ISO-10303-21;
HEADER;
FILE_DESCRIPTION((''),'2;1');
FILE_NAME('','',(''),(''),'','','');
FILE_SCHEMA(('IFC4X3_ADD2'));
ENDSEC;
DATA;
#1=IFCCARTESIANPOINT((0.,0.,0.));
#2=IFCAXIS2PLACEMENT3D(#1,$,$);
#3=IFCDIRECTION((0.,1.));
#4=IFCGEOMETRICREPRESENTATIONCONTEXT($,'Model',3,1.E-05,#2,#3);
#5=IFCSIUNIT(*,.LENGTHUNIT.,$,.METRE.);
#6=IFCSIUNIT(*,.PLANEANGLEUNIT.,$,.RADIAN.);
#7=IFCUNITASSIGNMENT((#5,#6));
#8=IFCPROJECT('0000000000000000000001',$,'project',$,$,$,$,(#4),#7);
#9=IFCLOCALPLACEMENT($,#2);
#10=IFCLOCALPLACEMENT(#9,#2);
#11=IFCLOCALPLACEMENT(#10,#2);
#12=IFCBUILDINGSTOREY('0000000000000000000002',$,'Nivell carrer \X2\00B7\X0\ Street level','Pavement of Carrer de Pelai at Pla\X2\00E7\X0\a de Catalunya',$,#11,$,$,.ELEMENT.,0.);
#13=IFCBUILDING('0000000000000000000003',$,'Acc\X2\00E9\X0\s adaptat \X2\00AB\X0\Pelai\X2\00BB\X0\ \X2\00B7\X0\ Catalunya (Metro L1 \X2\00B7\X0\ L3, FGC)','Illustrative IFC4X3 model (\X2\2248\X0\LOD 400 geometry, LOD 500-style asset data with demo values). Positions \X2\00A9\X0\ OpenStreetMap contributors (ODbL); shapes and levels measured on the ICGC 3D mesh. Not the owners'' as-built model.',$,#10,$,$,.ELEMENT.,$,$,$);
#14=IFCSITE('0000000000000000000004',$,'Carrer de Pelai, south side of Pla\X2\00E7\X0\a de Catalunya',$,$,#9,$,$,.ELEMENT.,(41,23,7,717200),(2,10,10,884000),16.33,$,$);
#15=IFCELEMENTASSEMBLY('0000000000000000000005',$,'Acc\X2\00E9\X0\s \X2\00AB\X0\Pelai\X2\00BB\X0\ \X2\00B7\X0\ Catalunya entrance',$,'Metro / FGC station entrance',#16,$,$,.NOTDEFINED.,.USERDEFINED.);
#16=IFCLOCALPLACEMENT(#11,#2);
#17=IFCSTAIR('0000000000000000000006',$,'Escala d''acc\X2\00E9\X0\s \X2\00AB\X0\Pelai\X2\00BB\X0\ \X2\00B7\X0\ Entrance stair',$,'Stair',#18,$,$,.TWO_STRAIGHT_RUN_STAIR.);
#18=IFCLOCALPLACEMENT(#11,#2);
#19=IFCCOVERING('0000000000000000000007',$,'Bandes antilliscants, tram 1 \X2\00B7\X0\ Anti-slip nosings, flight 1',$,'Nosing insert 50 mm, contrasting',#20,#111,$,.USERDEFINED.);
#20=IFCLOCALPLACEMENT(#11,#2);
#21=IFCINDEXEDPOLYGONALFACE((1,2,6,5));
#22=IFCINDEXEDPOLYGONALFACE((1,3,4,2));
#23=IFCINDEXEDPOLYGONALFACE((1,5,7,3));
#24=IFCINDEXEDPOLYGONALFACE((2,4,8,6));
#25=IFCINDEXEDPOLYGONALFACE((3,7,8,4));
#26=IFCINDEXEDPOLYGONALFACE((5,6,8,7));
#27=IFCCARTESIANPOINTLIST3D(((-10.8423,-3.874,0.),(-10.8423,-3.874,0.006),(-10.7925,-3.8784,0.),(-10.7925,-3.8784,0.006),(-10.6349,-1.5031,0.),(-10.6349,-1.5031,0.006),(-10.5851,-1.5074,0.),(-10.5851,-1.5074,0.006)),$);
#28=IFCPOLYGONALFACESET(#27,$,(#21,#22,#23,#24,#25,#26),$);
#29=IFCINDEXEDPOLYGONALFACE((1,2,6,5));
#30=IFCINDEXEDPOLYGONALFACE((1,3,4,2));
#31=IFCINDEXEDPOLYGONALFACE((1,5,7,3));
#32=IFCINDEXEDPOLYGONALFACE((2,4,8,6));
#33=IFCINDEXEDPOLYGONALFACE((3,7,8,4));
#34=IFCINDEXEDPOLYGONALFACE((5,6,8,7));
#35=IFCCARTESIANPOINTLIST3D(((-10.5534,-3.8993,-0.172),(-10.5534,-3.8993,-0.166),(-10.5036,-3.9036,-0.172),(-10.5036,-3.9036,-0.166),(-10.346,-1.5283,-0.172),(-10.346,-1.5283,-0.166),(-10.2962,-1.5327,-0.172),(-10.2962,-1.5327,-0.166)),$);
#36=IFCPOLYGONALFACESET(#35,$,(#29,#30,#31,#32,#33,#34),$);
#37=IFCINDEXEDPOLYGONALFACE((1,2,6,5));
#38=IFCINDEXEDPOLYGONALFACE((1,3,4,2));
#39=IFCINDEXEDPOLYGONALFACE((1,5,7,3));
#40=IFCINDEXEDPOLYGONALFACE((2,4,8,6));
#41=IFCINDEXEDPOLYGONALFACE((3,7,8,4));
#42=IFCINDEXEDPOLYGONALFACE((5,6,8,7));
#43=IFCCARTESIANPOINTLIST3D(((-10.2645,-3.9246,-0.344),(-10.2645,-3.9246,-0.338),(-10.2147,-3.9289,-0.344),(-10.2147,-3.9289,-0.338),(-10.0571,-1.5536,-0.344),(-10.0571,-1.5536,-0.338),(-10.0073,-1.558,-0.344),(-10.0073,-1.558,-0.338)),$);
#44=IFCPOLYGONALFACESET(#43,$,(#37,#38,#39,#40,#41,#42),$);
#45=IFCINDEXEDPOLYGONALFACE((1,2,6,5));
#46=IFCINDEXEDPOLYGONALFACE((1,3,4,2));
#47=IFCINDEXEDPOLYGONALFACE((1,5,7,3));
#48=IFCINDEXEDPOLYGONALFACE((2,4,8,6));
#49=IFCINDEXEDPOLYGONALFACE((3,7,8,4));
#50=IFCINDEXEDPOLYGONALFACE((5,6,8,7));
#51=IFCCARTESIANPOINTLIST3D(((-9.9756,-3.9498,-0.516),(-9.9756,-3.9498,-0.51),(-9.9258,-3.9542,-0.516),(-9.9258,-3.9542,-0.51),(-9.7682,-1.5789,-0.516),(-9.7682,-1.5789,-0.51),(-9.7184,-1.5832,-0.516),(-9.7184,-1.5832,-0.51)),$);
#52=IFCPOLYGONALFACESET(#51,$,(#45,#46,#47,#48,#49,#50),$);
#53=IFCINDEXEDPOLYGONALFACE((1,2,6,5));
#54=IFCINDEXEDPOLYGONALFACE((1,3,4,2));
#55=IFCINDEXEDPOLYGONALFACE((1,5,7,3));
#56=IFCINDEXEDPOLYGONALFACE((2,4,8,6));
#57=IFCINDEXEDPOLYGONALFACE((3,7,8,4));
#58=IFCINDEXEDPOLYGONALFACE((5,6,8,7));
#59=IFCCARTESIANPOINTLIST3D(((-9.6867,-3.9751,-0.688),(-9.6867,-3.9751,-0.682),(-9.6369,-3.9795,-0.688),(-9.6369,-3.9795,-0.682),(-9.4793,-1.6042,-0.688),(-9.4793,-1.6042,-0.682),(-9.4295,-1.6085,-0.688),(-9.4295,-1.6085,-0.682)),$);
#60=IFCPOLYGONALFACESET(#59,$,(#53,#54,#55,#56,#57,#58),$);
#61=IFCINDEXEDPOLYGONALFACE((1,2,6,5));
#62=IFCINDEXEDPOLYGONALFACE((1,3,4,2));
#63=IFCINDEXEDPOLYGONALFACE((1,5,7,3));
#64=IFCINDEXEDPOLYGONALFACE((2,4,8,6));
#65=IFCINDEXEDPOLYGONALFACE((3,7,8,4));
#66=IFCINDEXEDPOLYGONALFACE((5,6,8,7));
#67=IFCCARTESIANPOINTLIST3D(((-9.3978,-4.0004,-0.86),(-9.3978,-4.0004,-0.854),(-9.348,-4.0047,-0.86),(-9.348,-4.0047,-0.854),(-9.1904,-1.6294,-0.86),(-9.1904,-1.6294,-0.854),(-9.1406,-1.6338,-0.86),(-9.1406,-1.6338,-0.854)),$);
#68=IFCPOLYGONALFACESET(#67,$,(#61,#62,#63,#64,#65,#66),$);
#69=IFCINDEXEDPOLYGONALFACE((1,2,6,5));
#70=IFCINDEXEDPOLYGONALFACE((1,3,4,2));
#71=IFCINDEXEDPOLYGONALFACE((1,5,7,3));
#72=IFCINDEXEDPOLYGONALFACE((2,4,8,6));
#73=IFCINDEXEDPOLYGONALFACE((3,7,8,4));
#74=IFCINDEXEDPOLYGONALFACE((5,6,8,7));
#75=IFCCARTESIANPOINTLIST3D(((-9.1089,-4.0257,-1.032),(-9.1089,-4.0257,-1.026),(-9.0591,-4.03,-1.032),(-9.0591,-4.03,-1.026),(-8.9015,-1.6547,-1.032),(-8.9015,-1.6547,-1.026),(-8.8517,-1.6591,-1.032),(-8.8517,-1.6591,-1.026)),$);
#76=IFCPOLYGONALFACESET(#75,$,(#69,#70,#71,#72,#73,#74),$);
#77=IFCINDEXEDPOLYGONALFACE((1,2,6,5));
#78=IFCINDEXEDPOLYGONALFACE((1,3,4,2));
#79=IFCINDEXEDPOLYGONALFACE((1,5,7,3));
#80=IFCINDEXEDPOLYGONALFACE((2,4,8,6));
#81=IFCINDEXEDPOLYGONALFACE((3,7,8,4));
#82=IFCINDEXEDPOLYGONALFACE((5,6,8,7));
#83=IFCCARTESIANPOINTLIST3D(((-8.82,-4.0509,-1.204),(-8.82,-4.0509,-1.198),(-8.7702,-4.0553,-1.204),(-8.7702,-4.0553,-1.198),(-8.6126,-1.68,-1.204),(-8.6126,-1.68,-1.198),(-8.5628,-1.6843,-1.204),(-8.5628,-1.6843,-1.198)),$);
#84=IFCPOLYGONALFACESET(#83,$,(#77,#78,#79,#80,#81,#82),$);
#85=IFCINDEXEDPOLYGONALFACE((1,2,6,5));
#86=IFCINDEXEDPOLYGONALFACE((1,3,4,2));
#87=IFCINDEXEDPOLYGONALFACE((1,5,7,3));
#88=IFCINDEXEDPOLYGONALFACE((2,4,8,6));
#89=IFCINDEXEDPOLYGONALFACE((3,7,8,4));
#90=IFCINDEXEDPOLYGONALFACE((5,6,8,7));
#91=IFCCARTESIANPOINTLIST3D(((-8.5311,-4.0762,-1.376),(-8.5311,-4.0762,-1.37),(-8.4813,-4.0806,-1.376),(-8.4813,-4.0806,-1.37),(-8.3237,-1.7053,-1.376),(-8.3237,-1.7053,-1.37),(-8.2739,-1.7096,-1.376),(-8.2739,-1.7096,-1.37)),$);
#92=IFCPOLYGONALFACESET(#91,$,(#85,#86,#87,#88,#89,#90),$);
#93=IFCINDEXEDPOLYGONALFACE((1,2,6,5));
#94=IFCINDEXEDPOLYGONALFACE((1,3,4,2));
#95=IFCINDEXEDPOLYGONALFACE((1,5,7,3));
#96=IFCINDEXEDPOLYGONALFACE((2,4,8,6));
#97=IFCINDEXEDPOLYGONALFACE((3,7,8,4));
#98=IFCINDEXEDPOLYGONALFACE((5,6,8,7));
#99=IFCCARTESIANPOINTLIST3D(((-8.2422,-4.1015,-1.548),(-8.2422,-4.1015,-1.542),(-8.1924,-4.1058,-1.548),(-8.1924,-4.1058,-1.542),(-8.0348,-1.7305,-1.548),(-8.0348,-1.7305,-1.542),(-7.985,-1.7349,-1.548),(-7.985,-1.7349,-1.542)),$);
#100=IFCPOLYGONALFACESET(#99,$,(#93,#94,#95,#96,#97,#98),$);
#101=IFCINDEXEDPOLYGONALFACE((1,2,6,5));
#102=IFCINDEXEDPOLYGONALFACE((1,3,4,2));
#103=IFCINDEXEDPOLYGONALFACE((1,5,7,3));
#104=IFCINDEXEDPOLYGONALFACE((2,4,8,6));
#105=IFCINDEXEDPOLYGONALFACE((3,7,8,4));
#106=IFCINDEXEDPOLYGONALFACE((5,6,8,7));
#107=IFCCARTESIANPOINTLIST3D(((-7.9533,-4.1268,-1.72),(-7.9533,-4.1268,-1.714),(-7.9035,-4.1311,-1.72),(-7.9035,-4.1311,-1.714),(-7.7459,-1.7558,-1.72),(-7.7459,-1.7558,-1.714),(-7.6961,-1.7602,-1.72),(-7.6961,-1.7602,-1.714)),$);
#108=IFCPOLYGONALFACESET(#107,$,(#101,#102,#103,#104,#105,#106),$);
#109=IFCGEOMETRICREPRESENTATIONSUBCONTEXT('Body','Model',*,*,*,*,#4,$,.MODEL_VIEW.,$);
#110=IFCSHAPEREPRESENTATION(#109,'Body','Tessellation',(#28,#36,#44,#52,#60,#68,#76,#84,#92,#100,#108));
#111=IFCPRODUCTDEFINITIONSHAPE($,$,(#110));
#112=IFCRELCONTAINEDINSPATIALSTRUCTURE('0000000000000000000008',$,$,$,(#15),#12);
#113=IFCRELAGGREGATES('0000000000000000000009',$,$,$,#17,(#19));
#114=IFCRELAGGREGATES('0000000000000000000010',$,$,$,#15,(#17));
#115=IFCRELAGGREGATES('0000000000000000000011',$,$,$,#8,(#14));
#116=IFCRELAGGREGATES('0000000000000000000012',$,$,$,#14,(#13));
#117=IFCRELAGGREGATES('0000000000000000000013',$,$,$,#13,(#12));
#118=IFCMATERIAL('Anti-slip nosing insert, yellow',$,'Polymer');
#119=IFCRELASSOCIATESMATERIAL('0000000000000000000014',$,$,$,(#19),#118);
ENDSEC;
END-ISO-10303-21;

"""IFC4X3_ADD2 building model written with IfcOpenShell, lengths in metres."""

from ifc_helpers import new_model, si_unit, direction, frame, frame_2d, origin, place, context, subcontext, project, spatial, rectangle, extrude, material, element, aggregate, save


model = new_model("IFC4X3_ADD2")

# Units and contexts
model_context = context("Model", 3, precision=1e-05, world=origin(), true_north=direction((0.0, 1.0)))
body_context = subcontext(model_context, "Body", "Model", "MODEL_VIEW")
ifc_project = project(units=[si_unit("LENGTHUNIT", "METRE"), si_unit("PLANEANGLEUNIT", "RADIAN")], contexts=[model_context])

# Site, building, storey
site_placement = place(None, origin())
site = spatial("IfcSite", under=ifc_project, at=site_placement, Name="Carrer de Pelai, south side of Plaça de Catalunya", CompositionType="ELEMENT", RefLatitude=(41, 23, 7, 717200), RefLongitude=(2, 10, 10, 884000), RefElevation=16.33)
building_placement = place(site_placement, origin())
building = spatial("IfcBuilding", under=site, at=building_placement, Name="Accés adaptat «Pelai» · Catalunya (Metro L1 · L3, FGC)", Description="Illustrative IFC4X3 model (≈LOD 400 geometry, LOD 500-style asset data with demo values). Positions © OpenStreetMap contributors (ODbL); shapes and levels measured on the ICGC 3D mesh. Not the owners' as-built model.", CompositionType="ELEMENT")
storey_placement = place(building_placement, origin())
storey = spatial("IfcBuildingStorey", under=building, at=storey_placement, Name="Nivell carrer · Street level", Description="Pavement of Carrer de Pelai at Plaça de Catalunya", CompositionType="ELEMENT", Elevation=0.0)

# Element assembly
assembly_1_placement = place(building_placement, origin())
assembly_1 = element("IfcElementAssembly", 1, at=assembly_1_placement, inside=storey, Name="Accés «Pelai» · Catalunya entrance", ObjectType="Metro / FGC station entrance", AssemblyPlace="NOTDEFINED", PredefinedType="USERDEFINED")

# Stair
stair_placement = place(building_placement, origin())
stair = element("IfcStair", 2, at=stair_placement, Name="Escala d'accés «Pelai» · Entrance stair", ObjectType="Stair", PredefinedType="TWO_STRAIGHT_RUN_STAIR")

# Covering
ifc_material_1 = material(Name="Anti-slip nosing insert, yellow", Category="Polymer")
covering_1_placement = place(building_placement, origin())
covering_1 = element("IfcCovering", 3, at=covering_1_placement, material=ifc_material_1, Name="Bandes antilliscants, tram 1 · Anti-slip nosings, flight 1", ObjectType="Nosing insert 50 mm, contrasting", PredefinedType="USERDEFINED", context=body_context, shape_type="SweptSolid", body=[
    extrude(rectangle(XDim=0.05, YDim=2.38, at=frame_2d((0.0, 0.0), x_axis=(0.996195, -0.087156))), frame((-10.7137, -2.6907, 0.0)), (0.0, 0.0, 1.0), 0.006),
    extrude(rectangle(XDim=0.05, YDim=2.38, at=frame_2d((0.0, 0.0), x_axis=(0.996195, -0.087156))), frame((-10.4248, -2.716, -0.172)), (0.0, 0.0, 1.0), 0.006),
    extrude(rectangle(XDim=0.05, YDim=2.38, at=frame_2d((0.0, 0.0), x_axis=(0.996195, -0.087156))), frame((-10.1359, -2.7413, -0.344)), (0.0, 0.0, 1.0), 0.006),
    extrude(rectangle(XDim=0.05, YDim=2.38, at=frame_2d((0.0, 0.0), x_axis=(0.996195, -0.087156))), frame((-9.847, -2.7665, -0.516)), (0.0, 0.0, 1.0), 0.006),
    extrude(rectangle(XDim=0.05, YDim=2.38, at=frame_2d((0.0, 0.0), x_axis=(0.996195, -0.087156))), frame((-9.5581, -2.7918, -0.688)), (0.0, 0.0, 1.0), 0.006),
    extrude(rectangle(XDim=0.05, YDim=2.38, at=frame_2d((0.0, 0.0), x_axis=(0.996195, -0.087156))), frame((-9.2692, -2.8171, -0.86)), (0.0, 0.0, 1.0), 0.006),
    extrude(rectangle(XDim=0.05, YDim=2.38, at=frame_2d((0.0, 0.0), x_axis=(0.996195, -0.087156))), frame((-8.9803, -2.8424, -1.032)), (0.0, 0.0, 1.0), 0.006),
    extrude(rectangle(XDim=0.05, YDim=2.38, at=frame_2d((0.0, 0.0), x_axis=(0.996195, -0.087156))), frame((-8.6914, -2.8676, -1.204)), (0.0, 0.0, 1.0), 0.006),
    extrude(rectangle(XDim=0.05, YDim=2.38, at=frame_2d((0.0, 0.0), x_axis=(0.996195, -0.087156))), frame((-8.4025, -2.8929, -1.376)), (0.0, 0.0, 1.0), 0.006),
    extrude(rectangle(XDim=0.05, YDim=2.38, at=frame_2d((0.0, 0.0), x_axis=(0.996195, -0.087156))), frame((-8.1136, -2.9182, -1.548)), (0.0, 0.0, 1.0), 0.006),
    extrude(rectangle(XDim=0.05, YDim=2.38, at=frame_2d((0.0, 0.0), x_axis=(0.996195, -0.087156))), frame((-7.8247, -2.9435, -1.72)), (0.0, 0.0, 1.0), 0.006),
])

aggregate(stair, [covering_1])

aggregate(assembly_1, [stair])

save(model, "model.ifc")
